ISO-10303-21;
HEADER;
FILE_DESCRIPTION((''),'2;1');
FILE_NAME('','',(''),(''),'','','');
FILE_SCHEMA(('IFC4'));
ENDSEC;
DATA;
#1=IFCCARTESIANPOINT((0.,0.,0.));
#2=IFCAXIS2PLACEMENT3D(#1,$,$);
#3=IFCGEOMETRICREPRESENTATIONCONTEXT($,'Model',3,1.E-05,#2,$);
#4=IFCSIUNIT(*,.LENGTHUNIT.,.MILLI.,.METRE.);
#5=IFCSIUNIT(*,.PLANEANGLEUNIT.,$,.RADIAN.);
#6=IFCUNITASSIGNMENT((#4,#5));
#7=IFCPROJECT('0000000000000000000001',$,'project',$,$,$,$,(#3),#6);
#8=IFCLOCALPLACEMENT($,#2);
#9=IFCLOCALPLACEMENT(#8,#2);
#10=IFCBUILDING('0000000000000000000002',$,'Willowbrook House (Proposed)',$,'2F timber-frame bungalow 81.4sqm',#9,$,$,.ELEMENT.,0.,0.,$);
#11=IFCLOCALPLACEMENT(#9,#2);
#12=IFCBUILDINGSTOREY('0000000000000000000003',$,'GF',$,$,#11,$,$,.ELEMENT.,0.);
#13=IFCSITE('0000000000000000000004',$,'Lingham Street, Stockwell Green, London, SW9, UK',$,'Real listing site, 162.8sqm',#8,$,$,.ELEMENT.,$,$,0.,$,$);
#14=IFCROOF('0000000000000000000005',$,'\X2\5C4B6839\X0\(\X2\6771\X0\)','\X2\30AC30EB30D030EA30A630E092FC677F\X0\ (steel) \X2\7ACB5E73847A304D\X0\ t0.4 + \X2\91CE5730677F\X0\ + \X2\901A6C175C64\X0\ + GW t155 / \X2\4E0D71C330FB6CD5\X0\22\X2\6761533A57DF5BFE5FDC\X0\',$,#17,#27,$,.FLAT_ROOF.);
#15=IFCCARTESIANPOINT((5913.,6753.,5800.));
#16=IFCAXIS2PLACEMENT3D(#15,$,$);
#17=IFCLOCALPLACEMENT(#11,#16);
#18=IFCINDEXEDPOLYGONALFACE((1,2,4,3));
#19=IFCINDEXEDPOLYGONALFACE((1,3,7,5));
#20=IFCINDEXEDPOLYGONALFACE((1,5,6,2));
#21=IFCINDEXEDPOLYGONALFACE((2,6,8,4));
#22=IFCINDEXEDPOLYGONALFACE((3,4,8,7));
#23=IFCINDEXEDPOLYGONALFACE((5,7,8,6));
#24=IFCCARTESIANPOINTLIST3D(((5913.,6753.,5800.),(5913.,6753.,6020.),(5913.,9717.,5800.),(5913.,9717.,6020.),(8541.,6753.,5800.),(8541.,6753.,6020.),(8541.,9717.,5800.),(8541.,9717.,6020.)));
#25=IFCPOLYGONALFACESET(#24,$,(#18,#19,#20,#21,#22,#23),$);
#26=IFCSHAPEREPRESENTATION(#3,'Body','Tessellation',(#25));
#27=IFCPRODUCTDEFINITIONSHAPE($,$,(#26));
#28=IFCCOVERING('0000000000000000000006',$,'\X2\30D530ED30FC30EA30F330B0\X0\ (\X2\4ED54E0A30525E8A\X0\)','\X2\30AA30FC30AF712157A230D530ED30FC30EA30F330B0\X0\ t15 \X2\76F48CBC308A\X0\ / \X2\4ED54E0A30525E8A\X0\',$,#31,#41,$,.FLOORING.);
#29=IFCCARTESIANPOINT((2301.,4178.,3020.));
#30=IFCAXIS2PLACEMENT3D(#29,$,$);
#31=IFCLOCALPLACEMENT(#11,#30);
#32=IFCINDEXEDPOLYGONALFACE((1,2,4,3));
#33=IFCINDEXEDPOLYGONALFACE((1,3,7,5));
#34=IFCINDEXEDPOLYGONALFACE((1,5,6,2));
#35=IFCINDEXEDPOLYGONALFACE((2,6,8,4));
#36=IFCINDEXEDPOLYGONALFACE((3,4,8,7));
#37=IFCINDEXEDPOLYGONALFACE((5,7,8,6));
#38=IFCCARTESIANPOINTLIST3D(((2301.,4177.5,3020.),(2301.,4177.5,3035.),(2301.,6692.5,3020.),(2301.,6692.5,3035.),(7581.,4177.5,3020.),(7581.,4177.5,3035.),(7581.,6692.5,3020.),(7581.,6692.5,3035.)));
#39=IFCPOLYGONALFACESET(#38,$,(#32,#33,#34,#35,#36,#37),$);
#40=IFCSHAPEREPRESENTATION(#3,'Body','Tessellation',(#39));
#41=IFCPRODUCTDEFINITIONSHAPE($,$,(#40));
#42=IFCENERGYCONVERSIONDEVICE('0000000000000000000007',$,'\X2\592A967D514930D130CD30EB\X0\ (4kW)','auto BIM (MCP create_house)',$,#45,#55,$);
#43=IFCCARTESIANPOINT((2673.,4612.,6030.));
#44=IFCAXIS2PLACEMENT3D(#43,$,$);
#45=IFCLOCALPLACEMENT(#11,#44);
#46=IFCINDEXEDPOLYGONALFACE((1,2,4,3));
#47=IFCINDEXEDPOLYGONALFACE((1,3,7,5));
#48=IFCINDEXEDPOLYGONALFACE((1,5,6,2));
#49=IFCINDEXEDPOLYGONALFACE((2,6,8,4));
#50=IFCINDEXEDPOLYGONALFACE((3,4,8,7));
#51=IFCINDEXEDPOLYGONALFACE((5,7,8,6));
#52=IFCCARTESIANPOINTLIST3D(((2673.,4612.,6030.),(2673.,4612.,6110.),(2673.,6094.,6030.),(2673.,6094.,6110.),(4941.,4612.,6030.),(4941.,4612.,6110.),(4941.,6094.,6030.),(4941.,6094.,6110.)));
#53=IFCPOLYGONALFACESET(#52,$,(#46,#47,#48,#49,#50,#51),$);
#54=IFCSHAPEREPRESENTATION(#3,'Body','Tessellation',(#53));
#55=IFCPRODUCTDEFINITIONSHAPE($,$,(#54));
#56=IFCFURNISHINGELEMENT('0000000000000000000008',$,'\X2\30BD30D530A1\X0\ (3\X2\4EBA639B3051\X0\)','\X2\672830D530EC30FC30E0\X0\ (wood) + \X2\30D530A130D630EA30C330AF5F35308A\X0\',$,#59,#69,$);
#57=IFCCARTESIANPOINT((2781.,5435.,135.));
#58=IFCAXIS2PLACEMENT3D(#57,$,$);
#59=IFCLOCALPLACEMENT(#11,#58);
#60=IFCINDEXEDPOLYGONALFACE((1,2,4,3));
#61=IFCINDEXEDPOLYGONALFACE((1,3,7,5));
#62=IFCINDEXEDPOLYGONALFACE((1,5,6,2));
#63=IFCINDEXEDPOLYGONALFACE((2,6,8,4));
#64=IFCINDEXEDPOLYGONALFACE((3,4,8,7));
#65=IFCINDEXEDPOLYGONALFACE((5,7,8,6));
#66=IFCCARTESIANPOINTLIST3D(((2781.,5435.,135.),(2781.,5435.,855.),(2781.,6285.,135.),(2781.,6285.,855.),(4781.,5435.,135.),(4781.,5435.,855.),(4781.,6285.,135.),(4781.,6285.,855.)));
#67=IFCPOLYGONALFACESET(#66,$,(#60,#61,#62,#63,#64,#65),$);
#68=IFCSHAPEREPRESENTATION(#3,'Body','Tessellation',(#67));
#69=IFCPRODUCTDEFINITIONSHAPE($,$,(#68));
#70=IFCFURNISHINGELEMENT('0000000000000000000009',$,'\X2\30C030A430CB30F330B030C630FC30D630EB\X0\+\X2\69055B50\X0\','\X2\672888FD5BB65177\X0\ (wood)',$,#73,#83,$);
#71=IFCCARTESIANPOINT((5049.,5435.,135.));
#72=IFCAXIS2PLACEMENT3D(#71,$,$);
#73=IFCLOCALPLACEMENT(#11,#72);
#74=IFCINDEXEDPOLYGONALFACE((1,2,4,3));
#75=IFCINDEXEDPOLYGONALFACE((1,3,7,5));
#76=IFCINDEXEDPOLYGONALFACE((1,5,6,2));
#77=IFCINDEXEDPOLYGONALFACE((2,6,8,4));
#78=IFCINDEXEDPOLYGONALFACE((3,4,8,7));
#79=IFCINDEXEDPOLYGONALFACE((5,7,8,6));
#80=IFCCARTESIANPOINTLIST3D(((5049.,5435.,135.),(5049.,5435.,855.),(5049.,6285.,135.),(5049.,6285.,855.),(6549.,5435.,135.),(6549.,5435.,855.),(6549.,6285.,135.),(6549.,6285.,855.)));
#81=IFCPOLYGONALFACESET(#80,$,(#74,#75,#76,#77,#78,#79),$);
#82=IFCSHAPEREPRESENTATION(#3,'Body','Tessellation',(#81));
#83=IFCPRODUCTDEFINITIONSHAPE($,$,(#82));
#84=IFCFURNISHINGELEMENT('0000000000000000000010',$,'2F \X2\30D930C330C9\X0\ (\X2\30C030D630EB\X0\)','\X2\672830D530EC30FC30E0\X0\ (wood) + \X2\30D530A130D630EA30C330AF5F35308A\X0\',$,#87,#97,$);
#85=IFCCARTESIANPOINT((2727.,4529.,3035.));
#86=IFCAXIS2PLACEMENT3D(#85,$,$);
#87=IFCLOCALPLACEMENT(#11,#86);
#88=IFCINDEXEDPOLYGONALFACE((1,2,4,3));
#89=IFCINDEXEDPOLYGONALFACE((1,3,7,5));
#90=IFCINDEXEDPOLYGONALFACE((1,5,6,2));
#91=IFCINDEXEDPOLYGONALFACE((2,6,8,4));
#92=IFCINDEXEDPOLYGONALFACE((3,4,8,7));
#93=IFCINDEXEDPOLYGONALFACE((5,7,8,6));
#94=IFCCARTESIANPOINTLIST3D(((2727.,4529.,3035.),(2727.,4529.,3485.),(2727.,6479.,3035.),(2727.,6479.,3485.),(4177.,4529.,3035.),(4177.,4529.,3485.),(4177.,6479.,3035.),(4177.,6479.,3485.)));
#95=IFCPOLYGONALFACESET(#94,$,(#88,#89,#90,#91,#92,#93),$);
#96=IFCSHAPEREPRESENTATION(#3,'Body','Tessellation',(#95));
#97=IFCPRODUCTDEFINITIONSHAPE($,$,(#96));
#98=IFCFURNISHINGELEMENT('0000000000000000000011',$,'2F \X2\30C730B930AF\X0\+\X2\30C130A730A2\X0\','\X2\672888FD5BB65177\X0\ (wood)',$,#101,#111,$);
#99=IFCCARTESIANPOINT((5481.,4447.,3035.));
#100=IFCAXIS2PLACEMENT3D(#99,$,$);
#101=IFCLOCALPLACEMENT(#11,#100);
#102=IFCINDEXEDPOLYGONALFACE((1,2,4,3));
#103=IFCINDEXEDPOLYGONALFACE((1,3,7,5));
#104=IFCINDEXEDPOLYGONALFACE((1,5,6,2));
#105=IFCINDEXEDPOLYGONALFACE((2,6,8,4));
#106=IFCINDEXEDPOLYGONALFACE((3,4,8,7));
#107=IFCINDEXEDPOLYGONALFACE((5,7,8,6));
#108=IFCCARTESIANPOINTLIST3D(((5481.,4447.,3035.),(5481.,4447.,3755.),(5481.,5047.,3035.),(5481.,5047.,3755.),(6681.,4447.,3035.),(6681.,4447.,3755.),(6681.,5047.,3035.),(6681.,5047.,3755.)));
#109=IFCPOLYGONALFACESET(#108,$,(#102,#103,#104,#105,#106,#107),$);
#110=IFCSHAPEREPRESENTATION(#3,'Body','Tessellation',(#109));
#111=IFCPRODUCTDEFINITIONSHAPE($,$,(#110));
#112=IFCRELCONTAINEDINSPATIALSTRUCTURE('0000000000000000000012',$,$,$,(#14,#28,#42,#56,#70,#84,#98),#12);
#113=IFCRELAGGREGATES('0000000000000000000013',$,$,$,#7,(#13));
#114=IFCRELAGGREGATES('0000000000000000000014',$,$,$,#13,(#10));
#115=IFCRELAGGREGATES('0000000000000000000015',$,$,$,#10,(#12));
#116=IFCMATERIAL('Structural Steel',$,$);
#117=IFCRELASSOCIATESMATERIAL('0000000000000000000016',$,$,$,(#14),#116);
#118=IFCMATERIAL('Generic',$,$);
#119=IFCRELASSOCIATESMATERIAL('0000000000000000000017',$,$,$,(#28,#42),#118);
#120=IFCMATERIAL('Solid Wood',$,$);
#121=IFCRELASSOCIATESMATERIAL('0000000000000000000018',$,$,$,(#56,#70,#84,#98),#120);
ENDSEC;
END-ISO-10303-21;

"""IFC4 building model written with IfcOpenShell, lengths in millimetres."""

from ifc_helpers import new_model, si_unit, frame, frame_2d, origin, place, context, project, spatial, rectangle, extrude, material, element, save


model = new_model("IFC4")

# Units and contexts
model_context = context("Model", 3, precision=1e-05, world=origin())
ifc_project = project(units=[si_unit("LENGTHUNIT", "METRE", prefix="MILLI"), si_unit("PLANEANGLEUNIT", "RADIAN")], contexts=[model_context])

# Site, building, storey
site_placement = place(None, origin())
site = spatial("IfcSite", under=ifc_project, at=site_placement, Name="Lingham Street, Stockwell Green, London, SW9, UK", ObjectType="Real listing site, 162.8sqm", CompositionType="ELEMENT", RefElevation=0.0)
building_placement = place(site_placement, origin())
building = spatial("IfcBuilding", under=site, at=building_placement, Name="Willowbrook House (Proposed)", ObjectType="2F timber-frame bungalow 81.4sqm", CompositionType="ELEMENT", ElevationOfRefHeight=0.0, ElevationOfTerrain=0.0)
storey_placement = place(building_placement, origin())
storey = spatial("IfcBuildingStorey", under=building, at=storey_placement, Name="GF", CompositionType="ELEMENT", Elevation=0.0)

# Shared definitions
ifc_material_1 = material(Name="Solid Wood")

# Roof
ifc_material_2 = material(Name="Structural Steel")
roof_1_placement = place(storey_placement, frame((5913.0, 6753.0, 5800.0)))
element("IfcRoof", 1, at=roof_1_placement, inside=storey, material=ifc_material_2, Name="屋根(東)", Description="ガルバリウム鋼板 (steel) 立平葺き t0.4 + 野地板 + 通気層 + GW t155 / 不燃・法22条区域対応", PredefinedType="FLAT_ROOF", context=model_context, shape_type="SweptSolid", body=[
    extrude(rectangle(XDim=2628.0, YDim=2964.0, at=frame_2d((1314.0, 1482.0))), frame((5913.0, 6753.0, 5800.0)), (0.0, 0.0, 1.0), 220.0),
])

# Covering
ifc_material_3 = material(Name="Generic")
covering_placement = place(storey_placement, frame((2301.0, 4178.0, 3020.0)))
element("IfcCovering", 2, at=covering_placement, inside=storey, material=ifc_material_3, Name="フローリング (仕上げ床)", Description="オーク無垢フローリング t15 直貼り / 仕上げ床", PredefinedType="FLOORING", context=model_context, shape_type="SweptSolid", body=[
    extrude(rectangle(XDim=5280.0, YDim=2515.0, at=frame_2d((2640.0, 1257.0))), frame((2301.0, 4178.0, 3020.0)), (0.0, 0.0, 1.0), 15.0),
])

# Energy conversion device
energy_conversion_device_placement = place(storey_placement, frame((2673.0, 4612.0, 6030.0)))
element("IfcEnergyConversionDevice", 3, at=energy_conversion_device_placement, inside=storey, material=ifc_material_3, Name="太陽光パネル (4kW)", Description="auto BIM (MCP create_house)", context=model_context, shape_type="SweptSolid", body=[
    extrude(rectangle(XDim=2268.0, YDim=1482.0, at=frame_2d((1134.0, 741.0))), frame((2673.0, 4612.0, 6030.0)), (0.0, 0.0, 1.0), 80.0),
])

# Furnishing elements
furnishing_1_placement = place(storey_placement, frame((2781.0, 5435.0, 135.0)))
element("IfcFurnishingElement", 4, at=furnishing_1_placement, inside=storey, material=ifc_material_1, Name="ソファ (3人掛け)", Description="木フレーム (wood) + ファブリック張り", context=model_context, shape_type="SweptSolid", body=[
    extrude(rectangle(XDim=2000.0, YDim=850.0, at=frame_2d((1000.0, 425.0))), frame((2781.0, 5435.0, 135.0)), (0.0, 0.0, 1.0), 720.0),
])
furnishing_2_placement = place(storey_placement, frame((5049.0, 5435.0, 135.0)))
element("IfcFurnishingElement", 5, at=furnishing_2_placement, inside=storey, material=ifc_material_1, Name="ダイニングテーブル+椅子", Description="木製家具 (wood)", context=model_context, shape_type="SweptSolid", body=[
    extrude(rectangle(XDim=1500.0, YDim=850.0, at=frame_2d((750.0, 425.0))), frame((5049.0, 5435.0, 135.0)), (0.0, 0.0, 1.0), 720.0),
])
furnishing_3_placement = place(storey_placement, frame((2727.0, 4529.0, 3035.0)))
element("IfcFurnishingElement", 6, at=furnishing_3_placement, inside=storey, material=ifc_material_1, Name="2F ベッド (ダブル)", Description="木フレーム (wood) + ファブリック張り", context=model_context, shape_type="SweptSolid", body=[
    extrude(rectangle(XDim=1450.0, YDim=1950.0, at=frame_2d((725.0, 975.0))), frame((2727.0, 4529.0, 3035.0)), (0.0, 0.0, 1.0), 450.0),
])
furnishing_4_placement = place(storey_placement, frame((5481.0, 4447.0, 3035.0)))
element("IfcFurnishingElement", 7, at=furnishing_4_placement, inside=storey, material=ifc_material_1, Name="2F デスク+チェア", Description="木製家具 (wood)", context=model_context, shape_type="SweptSolid", body=[
    extrude(rectangle(XDim=1200.0, YDim=600.0, at=frame_2d((600.0, 300.0))), frame((5481.0, 4447.0, 3035.0)), (0.0, 0.0, 1.0), 720.0),
])

save(model, "model.ifc")
